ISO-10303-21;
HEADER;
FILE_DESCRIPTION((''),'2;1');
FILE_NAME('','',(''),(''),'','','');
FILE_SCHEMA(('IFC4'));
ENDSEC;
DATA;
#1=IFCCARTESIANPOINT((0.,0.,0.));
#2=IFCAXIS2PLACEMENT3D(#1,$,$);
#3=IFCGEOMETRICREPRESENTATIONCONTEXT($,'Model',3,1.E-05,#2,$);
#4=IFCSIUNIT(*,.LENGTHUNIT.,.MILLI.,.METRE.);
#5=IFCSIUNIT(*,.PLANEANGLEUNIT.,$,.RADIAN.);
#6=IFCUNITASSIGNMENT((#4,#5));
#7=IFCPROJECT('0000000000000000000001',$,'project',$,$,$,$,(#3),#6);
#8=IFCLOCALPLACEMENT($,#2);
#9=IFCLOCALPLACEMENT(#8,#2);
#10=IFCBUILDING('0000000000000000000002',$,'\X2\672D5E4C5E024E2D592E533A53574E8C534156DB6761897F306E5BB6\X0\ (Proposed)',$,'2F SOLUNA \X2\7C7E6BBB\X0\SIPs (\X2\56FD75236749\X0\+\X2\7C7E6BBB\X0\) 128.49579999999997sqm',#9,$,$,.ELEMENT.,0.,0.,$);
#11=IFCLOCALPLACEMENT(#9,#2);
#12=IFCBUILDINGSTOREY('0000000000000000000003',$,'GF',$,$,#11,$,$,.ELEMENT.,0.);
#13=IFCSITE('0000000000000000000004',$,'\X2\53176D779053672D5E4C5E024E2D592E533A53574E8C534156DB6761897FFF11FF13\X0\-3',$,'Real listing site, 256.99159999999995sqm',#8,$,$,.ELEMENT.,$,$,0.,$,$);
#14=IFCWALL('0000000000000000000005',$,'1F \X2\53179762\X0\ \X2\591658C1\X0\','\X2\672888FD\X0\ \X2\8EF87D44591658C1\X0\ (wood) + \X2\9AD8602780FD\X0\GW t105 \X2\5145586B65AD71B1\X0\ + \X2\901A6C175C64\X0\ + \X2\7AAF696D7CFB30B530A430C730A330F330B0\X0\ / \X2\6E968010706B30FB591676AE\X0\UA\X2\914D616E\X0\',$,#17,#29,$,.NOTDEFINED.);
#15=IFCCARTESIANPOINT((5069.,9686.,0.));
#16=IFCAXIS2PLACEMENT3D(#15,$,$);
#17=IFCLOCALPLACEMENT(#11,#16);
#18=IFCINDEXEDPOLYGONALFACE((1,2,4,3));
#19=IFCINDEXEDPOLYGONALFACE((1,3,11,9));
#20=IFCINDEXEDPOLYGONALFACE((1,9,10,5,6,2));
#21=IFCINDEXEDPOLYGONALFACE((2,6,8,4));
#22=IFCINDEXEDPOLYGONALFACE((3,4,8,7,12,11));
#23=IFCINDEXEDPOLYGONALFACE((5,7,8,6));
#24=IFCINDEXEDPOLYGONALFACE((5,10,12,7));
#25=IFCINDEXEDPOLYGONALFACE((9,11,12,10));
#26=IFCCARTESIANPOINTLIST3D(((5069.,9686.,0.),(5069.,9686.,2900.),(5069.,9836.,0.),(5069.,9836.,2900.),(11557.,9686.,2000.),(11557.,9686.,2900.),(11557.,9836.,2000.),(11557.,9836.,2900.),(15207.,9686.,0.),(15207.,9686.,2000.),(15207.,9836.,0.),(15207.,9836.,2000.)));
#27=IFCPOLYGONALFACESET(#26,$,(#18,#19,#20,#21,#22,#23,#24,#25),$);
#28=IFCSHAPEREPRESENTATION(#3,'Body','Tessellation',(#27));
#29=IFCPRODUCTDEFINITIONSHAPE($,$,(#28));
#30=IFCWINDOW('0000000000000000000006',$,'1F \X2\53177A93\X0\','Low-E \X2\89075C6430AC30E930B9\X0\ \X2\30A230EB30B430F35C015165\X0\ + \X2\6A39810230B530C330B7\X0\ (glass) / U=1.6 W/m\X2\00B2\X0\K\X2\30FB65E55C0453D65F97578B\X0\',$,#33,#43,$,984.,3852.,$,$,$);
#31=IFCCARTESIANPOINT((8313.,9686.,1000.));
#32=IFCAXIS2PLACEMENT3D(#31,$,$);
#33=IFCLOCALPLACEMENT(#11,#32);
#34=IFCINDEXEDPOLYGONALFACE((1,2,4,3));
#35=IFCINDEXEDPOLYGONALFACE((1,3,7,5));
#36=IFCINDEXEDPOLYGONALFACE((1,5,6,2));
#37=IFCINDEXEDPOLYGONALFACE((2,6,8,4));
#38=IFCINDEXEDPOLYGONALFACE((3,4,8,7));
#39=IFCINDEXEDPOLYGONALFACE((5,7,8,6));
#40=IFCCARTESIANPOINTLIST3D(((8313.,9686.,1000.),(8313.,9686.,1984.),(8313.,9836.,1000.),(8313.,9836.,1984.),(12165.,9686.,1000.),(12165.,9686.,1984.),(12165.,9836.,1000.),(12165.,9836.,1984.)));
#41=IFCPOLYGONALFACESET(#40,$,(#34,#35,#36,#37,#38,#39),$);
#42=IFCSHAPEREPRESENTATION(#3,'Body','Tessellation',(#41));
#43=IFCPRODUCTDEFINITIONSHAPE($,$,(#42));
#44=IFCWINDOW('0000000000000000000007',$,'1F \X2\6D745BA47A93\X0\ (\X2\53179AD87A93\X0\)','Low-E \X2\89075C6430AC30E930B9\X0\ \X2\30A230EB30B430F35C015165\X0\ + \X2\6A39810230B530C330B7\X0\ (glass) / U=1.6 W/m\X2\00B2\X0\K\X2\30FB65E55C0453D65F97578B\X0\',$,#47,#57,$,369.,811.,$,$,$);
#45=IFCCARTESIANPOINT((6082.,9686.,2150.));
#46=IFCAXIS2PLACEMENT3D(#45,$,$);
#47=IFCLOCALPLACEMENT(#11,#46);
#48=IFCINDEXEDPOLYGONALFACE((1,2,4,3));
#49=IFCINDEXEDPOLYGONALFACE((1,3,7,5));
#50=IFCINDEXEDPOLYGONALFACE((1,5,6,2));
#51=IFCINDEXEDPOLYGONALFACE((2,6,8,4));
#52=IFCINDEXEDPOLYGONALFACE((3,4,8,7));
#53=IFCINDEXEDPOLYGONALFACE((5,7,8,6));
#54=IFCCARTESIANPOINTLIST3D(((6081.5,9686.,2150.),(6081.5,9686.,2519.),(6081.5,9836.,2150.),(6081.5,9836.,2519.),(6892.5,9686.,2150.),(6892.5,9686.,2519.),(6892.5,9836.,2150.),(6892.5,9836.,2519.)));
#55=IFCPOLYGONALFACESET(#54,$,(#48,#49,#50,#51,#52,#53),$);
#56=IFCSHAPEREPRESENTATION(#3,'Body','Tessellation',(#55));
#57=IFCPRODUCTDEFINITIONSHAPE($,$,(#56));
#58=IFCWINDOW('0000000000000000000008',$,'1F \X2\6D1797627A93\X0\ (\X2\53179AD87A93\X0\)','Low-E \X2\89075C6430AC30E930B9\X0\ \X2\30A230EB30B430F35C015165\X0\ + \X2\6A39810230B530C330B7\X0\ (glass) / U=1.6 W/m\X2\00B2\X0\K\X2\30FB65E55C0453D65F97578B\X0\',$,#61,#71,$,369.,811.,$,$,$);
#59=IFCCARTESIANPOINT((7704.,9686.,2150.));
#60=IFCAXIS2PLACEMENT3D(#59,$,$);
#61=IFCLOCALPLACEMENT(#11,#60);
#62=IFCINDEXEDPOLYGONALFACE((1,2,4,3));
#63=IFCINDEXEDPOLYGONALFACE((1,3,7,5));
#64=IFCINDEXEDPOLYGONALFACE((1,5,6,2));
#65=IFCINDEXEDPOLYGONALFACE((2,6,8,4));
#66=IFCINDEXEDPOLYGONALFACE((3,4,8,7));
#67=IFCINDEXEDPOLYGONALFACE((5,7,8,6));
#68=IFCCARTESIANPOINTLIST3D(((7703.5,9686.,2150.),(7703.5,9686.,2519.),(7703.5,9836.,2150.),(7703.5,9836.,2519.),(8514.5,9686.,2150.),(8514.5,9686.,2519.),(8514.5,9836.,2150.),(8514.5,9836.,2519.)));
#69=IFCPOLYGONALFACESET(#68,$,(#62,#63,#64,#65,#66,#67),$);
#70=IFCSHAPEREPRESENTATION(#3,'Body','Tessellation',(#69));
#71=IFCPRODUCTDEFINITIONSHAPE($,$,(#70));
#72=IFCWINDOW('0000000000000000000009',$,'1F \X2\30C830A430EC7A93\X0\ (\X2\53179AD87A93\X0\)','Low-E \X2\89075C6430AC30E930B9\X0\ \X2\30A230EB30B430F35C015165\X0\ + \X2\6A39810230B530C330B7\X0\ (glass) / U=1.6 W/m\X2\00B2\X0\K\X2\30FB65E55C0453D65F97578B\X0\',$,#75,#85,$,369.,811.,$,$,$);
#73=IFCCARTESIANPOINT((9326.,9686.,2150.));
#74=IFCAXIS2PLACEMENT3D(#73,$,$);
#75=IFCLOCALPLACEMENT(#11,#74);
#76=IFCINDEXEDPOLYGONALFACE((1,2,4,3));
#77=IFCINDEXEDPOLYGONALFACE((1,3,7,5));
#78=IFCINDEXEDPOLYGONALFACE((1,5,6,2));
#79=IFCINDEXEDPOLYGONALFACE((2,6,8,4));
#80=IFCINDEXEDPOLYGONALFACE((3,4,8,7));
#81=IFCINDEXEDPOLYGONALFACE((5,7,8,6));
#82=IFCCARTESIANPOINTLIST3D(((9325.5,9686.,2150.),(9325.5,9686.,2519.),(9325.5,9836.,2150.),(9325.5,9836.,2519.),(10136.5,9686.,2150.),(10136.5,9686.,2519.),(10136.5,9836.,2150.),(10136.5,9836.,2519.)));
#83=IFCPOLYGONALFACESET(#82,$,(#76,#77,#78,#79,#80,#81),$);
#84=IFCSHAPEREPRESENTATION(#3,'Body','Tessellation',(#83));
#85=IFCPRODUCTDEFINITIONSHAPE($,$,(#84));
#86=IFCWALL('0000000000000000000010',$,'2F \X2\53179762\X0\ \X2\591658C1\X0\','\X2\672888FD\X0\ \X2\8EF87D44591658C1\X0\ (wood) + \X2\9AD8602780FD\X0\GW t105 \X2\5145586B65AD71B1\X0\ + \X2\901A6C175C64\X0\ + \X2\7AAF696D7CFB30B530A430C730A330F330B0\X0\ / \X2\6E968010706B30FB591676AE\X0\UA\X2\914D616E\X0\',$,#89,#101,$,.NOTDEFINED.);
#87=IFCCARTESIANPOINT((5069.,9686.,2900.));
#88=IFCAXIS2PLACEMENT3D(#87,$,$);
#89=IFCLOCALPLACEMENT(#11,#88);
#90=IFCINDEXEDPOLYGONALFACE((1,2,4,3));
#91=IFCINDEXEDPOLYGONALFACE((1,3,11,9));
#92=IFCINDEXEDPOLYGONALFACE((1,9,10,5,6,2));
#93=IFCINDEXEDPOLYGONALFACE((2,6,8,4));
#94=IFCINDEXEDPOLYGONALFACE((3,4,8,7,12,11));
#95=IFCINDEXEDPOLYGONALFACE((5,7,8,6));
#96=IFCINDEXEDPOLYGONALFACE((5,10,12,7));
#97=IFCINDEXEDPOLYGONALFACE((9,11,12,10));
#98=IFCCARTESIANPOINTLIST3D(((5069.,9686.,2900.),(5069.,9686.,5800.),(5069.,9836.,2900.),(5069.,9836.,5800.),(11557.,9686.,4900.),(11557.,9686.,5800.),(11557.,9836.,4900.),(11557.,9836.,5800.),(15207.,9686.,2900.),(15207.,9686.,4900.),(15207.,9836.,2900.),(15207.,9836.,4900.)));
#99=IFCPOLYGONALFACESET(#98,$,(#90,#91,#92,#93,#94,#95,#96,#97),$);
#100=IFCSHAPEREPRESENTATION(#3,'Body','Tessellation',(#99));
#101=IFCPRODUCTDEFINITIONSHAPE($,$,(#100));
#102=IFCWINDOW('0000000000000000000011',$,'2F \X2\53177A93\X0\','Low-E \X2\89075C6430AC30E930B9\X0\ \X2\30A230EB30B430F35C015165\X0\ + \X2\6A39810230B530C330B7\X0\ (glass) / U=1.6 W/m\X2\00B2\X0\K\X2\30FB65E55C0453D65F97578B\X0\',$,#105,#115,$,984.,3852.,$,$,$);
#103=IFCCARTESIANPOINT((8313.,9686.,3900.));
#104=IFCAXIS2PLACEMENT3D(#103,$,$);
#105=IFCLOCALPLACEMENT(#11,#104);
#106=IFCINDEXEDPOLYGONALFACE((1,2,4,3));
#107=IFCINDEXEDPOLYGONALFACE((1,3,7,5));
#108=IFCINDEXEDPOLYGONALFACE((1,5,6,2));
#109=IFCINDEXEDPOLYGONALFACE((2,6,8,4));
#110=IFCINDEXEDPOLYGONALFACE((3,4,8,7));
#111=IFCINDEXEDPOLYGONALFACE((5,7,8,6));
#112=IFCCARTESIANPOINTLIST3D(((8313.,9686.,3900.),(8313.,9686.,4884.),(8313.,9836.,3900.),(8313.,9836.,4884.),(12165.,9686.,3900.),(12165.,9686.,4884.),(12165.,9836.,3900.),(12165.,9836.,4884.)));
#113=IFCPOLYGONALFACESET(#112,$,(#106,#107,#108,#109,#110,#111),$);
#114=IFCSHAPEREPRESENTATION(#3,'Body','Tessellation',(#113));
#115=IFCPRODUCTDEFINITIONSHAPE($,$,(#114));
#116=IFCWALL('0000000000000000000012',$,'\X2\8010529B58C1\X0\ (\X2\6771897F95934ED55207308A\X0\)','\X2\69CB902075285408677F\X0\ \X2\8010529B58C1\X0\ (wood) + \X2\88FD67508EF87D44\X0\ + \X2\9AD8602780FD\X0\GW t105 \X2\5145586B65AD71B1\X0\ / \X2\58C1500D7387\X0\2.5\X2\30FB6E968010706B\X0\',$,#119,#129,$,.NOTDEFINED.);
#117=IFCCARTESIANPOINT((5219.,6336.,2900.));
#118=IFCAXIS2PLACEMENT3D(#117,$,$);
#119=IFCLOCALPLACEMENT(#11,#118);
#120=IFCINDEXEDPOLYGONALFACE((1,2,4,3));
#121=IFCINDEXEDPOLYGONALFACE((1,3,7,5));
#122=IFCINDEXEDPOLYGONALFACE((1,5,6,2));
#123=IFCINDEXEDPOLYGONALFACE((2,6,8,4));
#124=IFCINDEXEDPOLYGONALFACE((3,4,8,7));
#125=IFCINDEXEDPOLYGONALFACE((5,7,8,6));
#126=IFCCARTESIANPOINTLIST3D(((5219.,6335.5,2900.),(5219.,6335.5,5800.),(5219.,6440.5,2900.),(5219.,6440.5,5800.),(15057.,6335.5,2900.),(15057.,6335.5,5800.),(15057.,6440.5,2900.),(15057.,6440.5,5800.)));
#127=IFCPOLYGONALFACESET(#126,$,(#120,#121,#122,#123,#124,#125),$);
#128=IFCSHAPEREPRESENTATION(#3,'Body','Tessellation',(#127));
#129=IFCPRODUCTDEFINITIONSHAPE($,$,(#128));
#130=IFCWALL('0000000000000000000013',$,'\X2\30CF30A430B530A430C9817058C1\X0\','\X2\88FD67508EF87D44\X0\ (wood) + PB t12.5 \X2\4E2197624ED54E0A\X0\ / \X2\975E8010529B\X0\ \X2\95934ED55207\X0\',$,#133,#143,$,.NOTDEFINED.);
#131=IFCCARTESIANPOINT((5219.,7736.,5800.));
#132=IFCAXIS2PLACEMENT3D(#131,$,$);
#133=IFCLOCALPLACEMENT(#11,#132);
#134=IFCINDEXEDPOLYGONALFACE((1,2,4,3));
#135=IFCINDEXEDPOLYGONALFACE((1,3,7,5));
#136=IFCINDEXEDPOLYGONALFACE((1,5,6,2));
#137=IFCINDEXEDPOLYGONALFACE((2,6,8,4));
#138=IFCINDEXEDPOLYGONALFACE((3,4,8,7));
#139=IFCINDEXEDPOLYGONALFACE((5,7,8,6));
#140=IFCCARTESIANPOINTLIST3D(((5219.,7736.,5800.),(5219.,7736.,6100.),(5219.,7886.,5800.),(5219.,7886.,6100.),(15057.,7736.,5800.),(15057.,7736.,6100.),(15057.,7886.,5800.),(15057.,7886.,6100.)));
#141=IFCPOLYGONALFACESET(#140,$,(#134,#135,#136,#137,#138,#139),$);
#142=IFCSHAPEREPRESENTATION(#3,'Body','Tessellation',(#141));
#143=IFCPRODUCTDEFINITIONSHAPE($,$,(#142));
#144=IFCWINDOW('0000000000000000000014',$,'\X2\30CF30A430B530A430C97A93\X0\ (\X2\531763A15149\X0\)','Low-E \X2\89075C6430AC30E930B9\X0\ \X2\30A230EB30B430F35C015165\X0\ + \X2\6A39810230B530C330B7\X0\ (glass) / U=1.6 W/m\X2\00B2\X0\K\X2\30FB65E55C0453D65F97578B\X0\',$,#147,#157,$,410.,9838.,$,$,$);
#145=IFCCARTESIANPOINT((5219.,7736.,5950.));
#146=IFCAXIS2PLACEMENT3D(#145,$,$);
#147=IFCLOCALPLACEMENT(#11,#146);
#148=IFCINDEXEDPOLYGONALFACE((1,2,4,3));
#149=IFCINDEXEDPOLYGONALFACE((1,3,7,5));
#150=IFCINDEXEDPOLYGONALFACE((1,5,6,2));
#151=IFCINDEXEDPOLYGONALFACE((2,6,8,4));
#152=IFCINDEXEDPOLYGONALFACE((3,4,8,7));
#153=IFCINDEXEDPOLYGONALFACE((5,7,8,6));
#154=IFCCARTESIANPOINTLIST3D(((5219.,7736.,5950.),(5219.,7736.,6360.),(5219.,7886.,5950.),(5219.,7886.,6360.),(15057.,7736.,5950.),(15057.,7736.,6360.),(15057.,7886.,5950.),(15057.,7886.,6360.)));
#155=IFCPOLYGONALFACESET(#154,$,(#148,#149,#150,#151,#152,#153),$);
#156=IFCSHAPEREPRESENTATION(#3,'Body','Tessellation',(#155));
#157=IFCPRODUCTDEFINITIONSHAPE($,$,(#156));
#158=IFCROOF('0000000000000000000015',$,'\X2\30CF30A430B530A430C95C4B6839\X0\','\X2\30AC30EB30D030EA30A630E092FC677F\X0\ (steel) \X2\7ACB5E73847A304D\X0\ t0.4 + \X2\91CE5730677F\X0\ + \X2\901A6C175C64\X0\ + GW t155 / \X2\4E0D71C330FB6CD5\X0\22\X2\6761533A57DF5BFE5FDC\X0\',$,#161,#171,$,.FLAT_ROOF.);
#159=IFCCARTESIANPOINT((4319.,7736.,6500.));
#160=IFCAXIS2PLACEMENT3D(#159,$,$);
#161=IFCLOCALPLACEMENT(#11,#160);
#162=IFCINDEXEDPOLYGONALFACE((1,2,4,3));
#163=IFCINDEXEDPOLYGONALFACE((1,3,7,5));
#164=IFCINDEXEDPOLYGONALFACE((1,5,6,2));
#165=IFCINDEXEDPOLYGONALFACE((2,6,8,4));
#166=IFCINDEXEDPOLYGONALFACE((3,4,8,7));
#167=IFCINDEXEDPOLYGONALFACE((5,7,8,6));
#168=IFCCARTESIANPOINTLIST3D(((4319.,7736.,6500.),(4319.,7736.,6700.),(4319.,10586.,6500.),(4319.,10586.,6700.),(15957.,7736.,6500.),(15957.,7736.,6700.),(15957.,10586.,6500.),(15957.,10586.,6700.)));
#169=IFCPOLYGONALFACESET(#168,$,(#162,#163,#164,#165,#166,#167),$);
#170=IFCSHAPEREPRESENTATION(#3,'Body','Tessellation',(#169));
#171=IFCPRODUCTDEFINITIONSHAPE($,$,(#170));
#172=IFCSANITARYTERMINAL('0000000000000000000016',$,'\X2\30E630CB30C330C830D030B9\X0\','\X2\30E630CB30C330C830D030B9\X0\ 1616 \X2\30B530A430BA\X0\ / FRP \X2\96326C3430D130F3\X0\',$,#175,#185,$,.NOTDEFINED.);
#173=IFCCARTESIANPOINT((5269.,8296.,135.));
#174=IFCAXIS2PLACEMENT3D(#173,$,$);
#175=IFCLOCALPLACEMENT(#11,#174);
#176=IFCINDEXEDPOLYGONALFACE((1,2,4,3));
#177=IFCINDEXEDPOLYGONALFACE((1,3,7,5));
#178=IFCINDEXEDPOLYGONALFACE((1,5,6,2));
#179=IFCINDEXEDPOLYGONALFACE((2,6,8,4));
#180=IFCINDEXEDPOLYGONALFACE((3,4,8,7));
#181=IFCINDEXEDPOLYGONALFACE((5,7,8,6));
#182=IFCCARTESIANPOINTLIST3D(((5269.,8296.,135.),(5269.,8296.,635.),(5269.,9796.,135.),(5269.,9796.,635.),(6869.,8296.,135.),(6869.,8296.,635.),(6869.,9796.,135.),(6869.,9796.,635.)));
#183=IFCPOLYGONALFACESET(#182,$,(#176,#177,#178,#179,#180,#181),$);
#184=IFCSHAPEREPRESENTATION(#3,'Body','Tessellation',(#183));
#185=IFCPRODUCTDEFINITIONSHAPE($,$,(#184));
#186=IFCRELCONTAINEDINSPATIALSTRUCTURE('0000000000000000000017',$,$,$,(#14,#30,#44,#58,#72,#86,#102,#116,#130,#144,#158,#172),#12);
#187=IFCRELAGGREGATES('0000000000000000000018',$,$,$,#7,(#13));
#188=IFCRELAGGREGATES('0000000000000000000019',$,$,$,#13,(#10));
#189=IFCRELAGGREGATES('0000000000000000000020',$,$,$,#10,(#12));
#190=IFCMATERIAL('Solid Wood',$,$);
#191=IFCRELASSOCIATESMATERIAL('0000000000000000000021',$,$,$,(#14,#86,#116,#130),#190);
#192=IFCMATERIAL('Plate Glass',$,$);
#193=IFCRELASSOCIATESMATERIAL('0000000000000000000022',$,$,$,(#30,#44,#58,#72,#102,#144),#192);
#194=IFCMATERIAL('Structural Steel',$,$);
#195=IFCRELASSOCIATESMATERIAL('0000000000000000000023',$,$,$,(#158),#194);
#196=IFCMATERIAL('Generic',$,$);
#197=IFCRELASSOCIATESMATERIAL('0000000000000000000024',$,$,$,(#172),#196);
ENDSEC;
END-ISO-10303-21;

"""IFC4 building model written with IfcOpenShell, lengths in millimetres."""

from ifc_helpers import new_model, si_unit, frame, frame_2d, origin, place, context, project, spatial, rectangle, extrude, material, element, fill, save


model = new_model("IFC4")

# Units and contexts
model_context = context("Model", 3, precision=1e-05, world=origin())
ifc_project = project(units=[si_unit("LENGTHUNIT", "METRE", prefix="MILLI"), si_unit("PLANEANGLEUNIT", "RADIAN")], contexts=[model_context])

# Site, building, storey
site_placement = place(None, origin())
site = spatial("IfcSite", under=ifc_project, at=site_placement, Name="北海道札幌市中央区南二十四条西１３-3", ObjectType="Real listing site, 256.99159999999995sqm", CompositionType="ELEMENT", RefElevation=0.0)
building_placement = place(site_placement, origin())
building = spatial("IfcBuilding", under=site, at=building_placement, Name="札幌市中央区南二十四条西の家 (Proposed)", ObjectType="2F SOLUNA 籾殻SIPs (国産杉+籾殻) 128.49579999999997sqm", CompositionType="ELEMENT", ElevationOfRefHeight=0.0, ElevationOfTerrain=0.0)
storey_placement = place(building_placement, origin())
storey = spatial("IfcBuildingStorey", under=building, at=storey_placement, Name="GF", CompositionType="ELEMENT", Elevation=0.0)

# Wall, openings, windows
ifc_material_1 = material(Name="Solid Wood")
wall_1_placement = place(storey_placement, frame((5069.0, 9686.0, 0.0)))
wall_1 = element("IfcWall", 1, at=wall_1_placement, inside=storey, material=ifc_material_1, Name="1F 北面 外壁", Description="木製 軸組外壁 (wood) + 高性能GW t105 充填断熱 + 通気層 + 窯業系サイディング / 準耐火・外皮UA配慮", PredefinedType="NOTDEFINED", context=model_context, shape_type="SweptSolid", body=[
    extrude(rectangle(XDim=10138.0, YDim=150.0, at=frame_2d((5069.0, 75.0))), frame((5069.0, 9686.0, 0.0)), (0.0, 0.0, 1.0), 2900.0),
])
opening_1_placement = place(storey_placement, frame((8313.0, 9686.0, 1000.0)))
opening_1 = element("IfcOpeningElement", 2, at=opening_1_placement, cuts=wall_1, PredefinedType="NOTDEFINED", context=model_context, shape_type="SweptSolid", body=[
    extrude(rectangle(XDim=3852.0, YDim=150.0, at=frame_2d((1926.0, 75.0))), frame((8313.0, 9686.0, 1000.0)), (0.0, 0.0, 1.0), 984.0),
])
opening_2_placement = place(storey_placement, frame((6082.0, 9686.0, 2150.0)))
opening_2 = element("IfcOpeningElement", 3, at=opening_2_placement, cuts=wall_1, PredefinedType="NOTDEFINED", context=model_context, shape_type="SweptSolid", body=[
    extrude(rectangle(XDim=811.0, YDim=150.0, at=frame_2d((405.0, 75.0))), frame((6082.0, 9686.0, 2150.0)), (0.0, 0.0, 1.0), 369.0),
])
opening_3_placement = place(storey_placement, frame((7704.0, 9686.0, 2150.0)))
opening_3 = element("IfcOpeningElement", 4, at=opening_3_placement, cuts=wall_1, PredefinedType="NOTDEFINED", context=model_context, shape_type="SweptSolid", body=[
    extrude(rectangle(XDim=811.0, YDim=150.0, at=frame_2d((405.0, 75.0))), frame((7704.0, 9686.0, 2150.0)), (0.0, 0.0, 1.0), 369.0),
])
opening_4_placement = place(storey_placement, frame((9326.0, 9686.0, 2150.0)))
opening_4 = element("IfcOpeningElement", 5, at=opening_4_placement, cuts=wall_1, PredefinedType="NOTDEFINED", context=model_context, shape_type="SweptSolid", body=[
    extrude(rectangle(XDim=811.0, YDim=150.0, at=frame_2d((405.0, 75.0))), frame((9326.0, 9686.0, 2150.0)), (0.0, 0.0, 1.0), 369.0),
])
ifc_material_2 = material(Name="Plate Glass")
window_1_placement = place(storey_placement, frame((8313.0, 9686.0, 1000.0)))
window_1 = element("IfcWindow", 6, at=window_1_placement, inside=storey, material=ifc_material_2, Name="1F 北窓", Description="Low-E 複層ガラス アルゴン封入 + 樹脂サッシ (glass) / U=1.6 W/m²K・日射取得型", OverallHeight=984.0, OverallWidth=3852.0, context=model_context, shape_type="SweptSolid", body=[
    extrude(rectangle(XDim=3852.0, YDim=150.0, at=frame_2d((1926.0, 75.0))), frame((8313.0, 9686.0, 1000.0)), (0.0, 0.0, 1.0), 984.0),
])
fill(opening_1, window_1)
window_2_placement = place(storey_placement, frame((6082.0, 9686.0, 2150.0)))
window_2 = element("IfcWindow", 7, at=window_2_placement, inside=storey, material=ifc_material_2, Name="1F 浴室窓 (北高窓)", Description="Low-E 複層ガラス アルゴン封入 + 樹脂サッシ (glass) / U=1.6 W/m²K・日射取得型", OverallHeight=369.0, OverallWidth=811.0, context=model_context, shape_type="SweptSolid", body=[
    extrude(rectangle(XDim=811.0, YDim=150.0, at=frame_2d((405.0, 75.0))), frame((6082.0, 9686.0, 2150.0)), (0.0, 0.0, 1.0), 369.0),
])
fill(opening_2, window_2)
window_3_placement = place(storey_placement, frame((7704.0, 9686.0, 2150.0)))
window_3 = element("IfcWindow", 8, at=window_3_placement, inside=storey, material=ifc_material_2, Name="1F 洗面窓 (北高窓)", Description="Low-E 複層ガラス アルゴン封入 + 樹脂サッシ (glass) / U=1.6 W/m²K・日射取得型", OverallHeight=369.0, OverallWidth=811.0, context=model_context, shape_type="SweptSolid", body=[
    extrude(rectangle(XDim=811.0, YDim=150.0, at=frame_2d((405.0, 75.0))), frame((7704.0, 9686.0, 2150.0)), (0.0, 0.0, 1.0), 369.0),
])
fill(opening_3, window_3)
window_4_placement = place(storey_placement, frame((9326.0, 9686.0, 2150.0)))
window_4 = element("IfcWindow", 9, at=window_4_placement, inside=storey, material=ifc_material_2, Name="1F トイレ窓 (北高窓)", Description="Low-E 複層ガラス アルゴン封入 + 樹脂サッシ (glass) / U=1.6 W/m²K・日射取得型", OverallHeight=369.0, OverallWidth=811.0, context=model_context, shape_type="SweptSolid", body=[
    extrude(rectangle(XDim=811.0, YDim=150.0, at=frame_2d((405.0, 75.0))), frame((9326.0, 9686.0, 2150.0)), (0.0, 0.0, 1.0), 369.0),
])
fill(opening_4, window_4)

# Wall, opening, window
wall_2_placement = place(storey_placement, frame((5069.0, 9686.0, 2900.0)))
wall_2 = element("IfcWall", 10, at=wall_2_placement, inside=storey, material=ifc_material_1, Name="2F 北面 外壁", Description="木製 軸組外壁 (wood) + 高性能GW t105 充填断熱 + 通気層 + 窯業系サイディング / 準耐火・外皮UA配慮", PredefinedType="NOTDEFINED", context=model_context, shape_type="SweptSolid", body=[
    extrude(rectangle(XDim=10138.0, YDim=150.0, at=frame_2d((5069.0, 75.0))), frame((5069.0, 9686.0, 2900.0)), (0.0, 0.0, 1.0), 2900.0),
])
opening_5_placement = place(storey_placement, frame((8313.0, 9686.0, 3900.0)))
opening_5 = element("IfcOpeningElement", 11, at=opening_5_placement, cuts=wall_2, PredefinedType="NOTDEFINED", context=model_context, shape_type="SweptSolid", body=[
    extrude(rectangle(XDim=3852.0, YDim=150.0, at=frame_2d((1926.0, 75.0))), frame((8313.0, 9686.0, 3900.0)), (0.0, 0.0, 1.0), 984.0),
])
window_5_placement = place(storey_placement, frame((8313.0, 9686.0, 3900.0)))
window_5 = element("IfcWindow", 12, at=window_5_placement, inside=storey, material=ifc_material_2, Name="2F 北窓", Description="Low-E 複層ガラス アルゴン封入 + 樹脂サッシ (glass) / U=1.6 W/m²K・日射取得型", OverallHeight=984.0, OverallWidth=3852.0, context=model_context, shape_type="SweptSolid", body=[
    extrude(rectangle(XDim=3852.0, YDim=150.0, at=frame_2d((1926.0, 75.0))), frame((8313.0, 9686.0, 3900.0)), (0.0, 0.0, 1.0), 984.0),
])
fill(opening_5, window_5)

# Wall
wall_3_placement = place(storey_placement, frame((5219.0, 6336.0, 2900.0)))
element("IfcWall", 13, at=wall_3_placement, inside=storey, material=ifc_material_1, Name="耐力壁 (東西間仕切り)", Description="構造用合板 耐力壁 (wood) + 製材軸組 + 高性能GW t105 充填断熱 / 壁倍率2.5・準耐火", PredefinedType="NOTDEFINED", context=model_context, shape_type="SweptSolid", body=[
    extrude(rectangle(XDim=9838.0, YDim=105.0, at=frame_2d((4919.0, 52.0))), frame((5219.0, 6336.0, 2900.0)), (0.0, 0.0, 1.0), 2900.0),
])

# Wall, opening, window
wall_4_placement = place(storey_placement, frame((5219.0, 7736.0, 5800.0)))
wall_4 = element("IfcWall", 14, at=wall_4_placement, inside=storey, material=ifc_material_1, Name="ハイサイド腰壁", Description="製材軸組 (wood) + PB t12.5 両面仕上 / 非耐力 間仕切", PredefinedType="NOTDEFINED", context=model_context, shape_type="SweptSolid", body=[
    extrude(rectangle(XDim=9838.0, YDim=150.0, at=frame_2d((4919.0, 75.0))), frame((5219.0, 7736.0, 5800.0)), (0.0, 0.0, 1.0), 700.0),
])
opening_6_placement = place(storey_placement, frame((5219.0, 7736.0, 5950.0)))
opening_6 = element("IfcOpeningElement", 15, at=opening_6_placement, cuts=wall_4, PredefinedType="NOTDEFINED", context=model_context, shape_type="SweptSolid", body=[
    extrude(rectangle(XDim=9838.0, YDim=150.0, at=frame_2d((4919.0, 75.0))), frame((5219.0, 7736.0, 5950.0)), (0.0, 0.0, 1.0), 410.0),
])
window_6_placement = place(storey_placement, frame((5219.0, 7736.0, 5950.0)))
window_6 = element("IfcWindow", 16, at=window_6_placement, inside=storey, material=ifc_material_2, Name="ハイサイド窓 (北採光)", Description="Low-E 複層ガラス アルゴン封入 + 樹脂サッシ (glass) / U=1.6 W/m²K・日射取得型", OverallHeight=410.0, OverallWidth=9838.0, context=model_context, shape_type="SweptSolid", body=[
    extrude(rectangle(XDim=9838.0, YDim=150.0, at=frame_2d((4919.0, 75.0))), frame((5219.0, 7736.0, 5950.0)), (0.0, 0.0, 1.0), 410.0),
])
fill(opening_6, window_6)

# Roof
ifc_material_3 = material(Name="Structural Steel")
roof_placement = place(storey_placement, frame((4319.0, 7736.0, 6500.0)))
element("IfcRoof", 17, at=roof_placement, inside=storey, material=ifc_material_3, Name="ハイサイド屋根", Description="ガルバリウム鋼板 (steel) 立平葺き t0.4 + 野地板 + 通気層 + GW t155 / 不燃・法22条区域対応", PredefinedType="FLAT_ROOF", context=model_context, shape_type="SweptSolid", body=[
    extrude(rectangle(XDim=11638.0, YDim=2850.0, at=frame_2d((5819.0, 1425.0))), frame((4319.0, 7736.0, 6500.0)), (0.0, 0.0, 1.0), 200.0),
])

# Sanitary terminal
ifc_material_4 = material(Name="Generic")
sanitary_terminal_placement = place(storey_placement, frame((5269.0, 8296.0, 135.0)))
element("IfcSanitaryTerminal", 18, at=sanitary_terminal_placement, inside=storey, material=ifc_material_4, Name="ユニットバス", Description="ユニットバス 1616 サイズ / FRP 防水パン", PredefinedType="NOTDEFINED", context=model_context, shape_type="SweptSolid", body=[
    extrude(rectangle(XDim=1600.0, YDim=1500.0, at=frame_2d((800.0, 750.0))), frame((5269.0, 8296.0, 135.0)), (0.0, 0.0, 1.0), 500.0),
])

save(model, "model.ifc")
